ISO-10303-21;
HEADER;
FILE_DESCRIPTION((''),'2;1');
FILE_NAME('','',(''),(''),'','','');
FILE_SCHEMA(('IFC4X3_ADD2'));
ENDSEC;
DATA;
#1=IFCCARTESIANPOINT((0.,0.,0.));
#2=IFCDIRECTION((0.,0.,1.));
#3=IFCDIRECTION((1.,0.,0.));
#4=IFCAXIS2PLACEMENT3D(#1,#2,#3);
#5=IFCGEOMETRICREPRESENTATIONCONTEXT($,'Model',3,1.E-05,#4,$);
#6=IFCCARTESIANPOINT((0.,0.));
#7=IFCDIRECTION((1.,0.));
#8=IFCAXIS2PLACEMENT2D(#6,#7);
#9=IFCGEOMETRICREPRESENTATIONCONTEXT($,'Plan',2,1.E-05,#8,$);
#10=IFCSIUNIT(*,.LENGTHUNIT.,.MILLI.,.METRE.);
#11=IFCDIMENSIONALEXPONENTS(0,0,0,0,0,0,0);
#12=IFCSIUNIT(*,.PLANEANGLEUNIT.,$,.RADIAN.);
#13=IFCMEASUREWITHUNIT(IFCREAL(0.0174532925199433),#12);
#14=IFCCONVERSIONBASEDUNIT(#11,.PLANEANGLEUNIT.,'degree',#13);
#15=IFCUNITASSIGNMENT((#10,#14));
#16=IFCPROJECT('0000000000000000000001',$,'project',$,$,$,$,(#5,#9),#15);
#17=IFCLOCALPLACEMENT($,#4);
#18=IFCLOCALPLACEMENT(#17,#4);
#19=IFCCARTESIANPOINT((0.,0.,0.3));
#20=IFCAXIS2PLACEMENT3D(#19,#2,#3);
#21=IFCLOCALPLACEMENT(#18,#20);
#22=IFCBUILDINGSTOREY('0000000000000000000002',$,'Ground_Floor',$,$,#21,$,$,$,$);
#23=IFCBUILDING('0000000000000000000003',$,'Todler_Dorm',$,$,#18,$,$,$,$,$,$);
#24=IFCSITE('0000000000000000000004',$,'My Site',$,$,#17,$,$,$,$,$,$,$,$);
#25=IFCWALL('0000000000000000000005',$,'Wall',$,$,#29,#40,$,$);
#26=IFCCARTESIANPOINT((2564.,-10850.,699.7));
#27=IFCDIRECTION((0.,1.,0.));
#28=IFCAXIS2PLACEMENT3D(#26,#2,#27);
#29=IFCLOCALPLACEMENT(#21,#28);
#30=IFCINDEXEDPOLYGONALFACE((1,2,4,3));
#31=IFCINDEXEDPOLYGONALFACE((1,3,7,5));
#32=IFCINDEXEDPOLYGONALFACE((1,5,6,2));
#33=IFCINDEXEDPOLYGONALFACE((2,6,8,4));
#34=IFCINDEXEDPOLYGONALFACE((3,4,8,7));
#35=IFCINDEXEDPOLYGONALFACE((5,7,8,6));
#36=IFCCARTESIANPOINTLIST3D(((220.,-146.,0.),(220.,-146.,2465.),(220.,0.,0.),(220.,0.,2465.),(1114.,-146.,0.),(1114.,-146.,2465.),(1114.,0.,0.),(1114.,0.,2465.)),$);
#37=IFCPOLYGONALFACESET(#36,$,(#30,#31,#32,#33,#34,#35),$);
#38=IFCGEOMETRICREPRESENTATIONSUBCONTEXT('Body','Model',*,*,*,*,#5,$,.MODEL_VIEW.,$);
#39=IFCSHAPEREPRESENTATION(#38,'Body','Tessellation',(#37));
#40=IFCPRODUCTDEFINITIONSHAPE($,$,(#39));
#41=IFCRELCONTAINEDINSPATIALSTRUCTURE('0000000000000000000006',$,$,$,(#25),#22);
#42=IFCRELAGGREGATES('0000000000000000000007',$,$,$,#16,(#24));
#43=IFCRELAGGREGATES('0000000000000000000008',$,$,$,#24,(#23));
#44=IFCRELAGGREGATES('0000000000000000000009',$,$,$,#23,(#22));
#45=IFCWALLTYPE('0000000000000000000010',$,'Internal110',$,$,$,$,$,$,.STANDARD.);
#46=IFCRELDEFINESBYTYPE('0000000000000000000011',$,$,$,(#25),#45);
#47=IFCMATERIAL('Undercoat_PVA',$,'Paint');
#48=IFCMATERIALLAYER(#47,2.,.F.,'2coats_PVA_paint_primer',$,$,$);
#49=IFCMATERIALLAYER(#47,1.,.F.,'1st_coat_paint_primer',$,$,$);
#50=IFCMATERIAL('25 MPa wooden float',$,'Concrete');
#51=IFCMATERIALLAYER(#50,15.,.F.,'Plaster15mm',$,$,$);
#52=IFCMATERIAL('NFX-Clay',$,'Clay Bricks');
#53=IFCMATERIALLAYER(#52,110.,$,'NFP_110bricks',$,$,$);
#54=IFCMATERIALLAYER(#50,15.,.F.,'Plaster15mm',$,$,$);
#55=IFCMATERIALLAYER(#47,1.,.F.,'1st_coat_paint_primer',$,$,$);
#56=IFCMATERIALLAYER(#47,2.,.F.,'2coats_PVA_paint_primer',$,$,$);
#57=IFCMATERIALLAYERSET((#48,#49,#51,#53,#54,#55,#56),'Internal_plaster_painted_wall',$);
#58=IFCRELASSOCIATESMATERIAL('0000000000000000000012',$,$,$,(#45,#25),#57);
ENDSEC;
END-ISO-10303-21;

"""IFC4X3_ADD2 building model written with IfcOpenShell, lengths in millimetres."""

from ifc_helpers import new_model, entity, si_unit, converted_unit, frame, origin_with_axes, origin_2d_with_axis, place, context, subcontext, project, spatial, line, indexed_curve, outline, extrude, material, layer, layer_set, layer_usage, type_object, element, save


model = new_model("IFC4X3_ADD2")

# Units and contexts
model_context = context("Model", 3, precision=1e-05, world=origin_with_axes())
plan_context = context("Plan", 2, precision=1e-05, world=origin_2d_with_axis())
body_context_1 = subcontext(model_context, "Body", "Model", "MODEL_VIEW")
ifc_project = project(units=[si_unit("LENGTHUNIT", "METRE", prefix="MILLI"), converted_unit("PLANEANGLEUNIT", "degree", entity("IfcReal", 0.0174532925199433), si_unit("PLANEANGLEUNIT", "RADIAN"), dimensions=[0, 0, 0, 0, 0, 0, 0])], contexts=[model_context, plan_context])

# Site, building, storey
site_placement = place(None, origin_with_axes())
site = spatial("IfcSite", under=ifc_project, at=site_placement, Name="My Site")
building_placement = place(site_placement, origin_with_axes())
building = spatial("IfcBuilding", under=site, at=building_placement, Name="Todler_Dorm")
storey_placement = place(building_placement, frame((0.0, 0.0, 0.3), z_axis=(0.0, 0.0, 1.0), x_axis=(1.0, 0.0, 0.0)))
storey = spatial("IfcBuildingStorey", under=building, at=storey_placement, Name="Ground_Floor")

# Shared definitions
ifc_material_1 = material(Name="Undercoat_PVA", Category="Paint")
ifc_layer_1 = layer(ifc_material_1, 2.0, ventilated=False, Name="2coats_PVA_paint_primer")
ifc_layer_2 = layer(ifc_material_1, 1.0, ventilated=False, Name="1st_coat_paint_primer")
ifc_material_2 = material(Name="25 MPa wooden float", Category="Concrete")
ifc_layer_3 = layer(ifc_material_2, 15.0, ventilated=False, Name="Plaster15mm")
ifc_material_3 = material(Name="NFX-Clay", Category="Clay Bricks")
ifc_layer_4 = layer(ifc_material_3, 110.0, Name="NFP_110bricks")
ifc_layer_5 = layer(ifc_material_2, 15.0, ventilated=False, Name="Plaster15mm")
ifc_layer_6 = layer(ifc_material_1, 1.0, ventilated=False, Name="1st_coat_paint_primer")
ifc_layer_7 = layer(ifc_material_1, 2.0, ventilated=False, Name="2coats_PVA_paint_primer")
ifc_layer_set_1 = layer_set([ifc_layer_1, ifc_layer_2, ifc_layer_3, ifc_layer_4, ifc_layer_5, ifc_layer_6, ifc_layer_7], Name="Internal_plaster_painted_wall")
wall_type_1 = type_object("IfcWallType", Name="Internal110", PredefinedType="STANDARD", material=ifc_layer_set_1)

# Wall
ifc_layer_usage_1 = layer_usage(ifc_layer_set_1, "AXIS2", "NEGATIVE", 0.0)
wall_1_placement = place(storey_placement, frame((2564.0, -10850.0, 699.7), z_axis=(0.0, 0.0, 1.0), x_axis=(0.0, 1.0, 0.0)))
element("IfcWall", 1, at=wall_1_placement, inside=storey, type_object=wall_type_1, material=ifc_layer_usage_1, Name="Wall", context=body_context_1, shape_type="SweptSolid", body=[
    extrude(outline(indexed_curve([(220.0, -146.0), (220.0, 0.0), (1114.0, 0.0), (1114.0, -146.0)], segments=[line(1, 2, 3, 4, 1)])), origin_with_axes(), (0.0, 0.0, 1.0), 2465.0),
])

save(model, "model.ifc")
